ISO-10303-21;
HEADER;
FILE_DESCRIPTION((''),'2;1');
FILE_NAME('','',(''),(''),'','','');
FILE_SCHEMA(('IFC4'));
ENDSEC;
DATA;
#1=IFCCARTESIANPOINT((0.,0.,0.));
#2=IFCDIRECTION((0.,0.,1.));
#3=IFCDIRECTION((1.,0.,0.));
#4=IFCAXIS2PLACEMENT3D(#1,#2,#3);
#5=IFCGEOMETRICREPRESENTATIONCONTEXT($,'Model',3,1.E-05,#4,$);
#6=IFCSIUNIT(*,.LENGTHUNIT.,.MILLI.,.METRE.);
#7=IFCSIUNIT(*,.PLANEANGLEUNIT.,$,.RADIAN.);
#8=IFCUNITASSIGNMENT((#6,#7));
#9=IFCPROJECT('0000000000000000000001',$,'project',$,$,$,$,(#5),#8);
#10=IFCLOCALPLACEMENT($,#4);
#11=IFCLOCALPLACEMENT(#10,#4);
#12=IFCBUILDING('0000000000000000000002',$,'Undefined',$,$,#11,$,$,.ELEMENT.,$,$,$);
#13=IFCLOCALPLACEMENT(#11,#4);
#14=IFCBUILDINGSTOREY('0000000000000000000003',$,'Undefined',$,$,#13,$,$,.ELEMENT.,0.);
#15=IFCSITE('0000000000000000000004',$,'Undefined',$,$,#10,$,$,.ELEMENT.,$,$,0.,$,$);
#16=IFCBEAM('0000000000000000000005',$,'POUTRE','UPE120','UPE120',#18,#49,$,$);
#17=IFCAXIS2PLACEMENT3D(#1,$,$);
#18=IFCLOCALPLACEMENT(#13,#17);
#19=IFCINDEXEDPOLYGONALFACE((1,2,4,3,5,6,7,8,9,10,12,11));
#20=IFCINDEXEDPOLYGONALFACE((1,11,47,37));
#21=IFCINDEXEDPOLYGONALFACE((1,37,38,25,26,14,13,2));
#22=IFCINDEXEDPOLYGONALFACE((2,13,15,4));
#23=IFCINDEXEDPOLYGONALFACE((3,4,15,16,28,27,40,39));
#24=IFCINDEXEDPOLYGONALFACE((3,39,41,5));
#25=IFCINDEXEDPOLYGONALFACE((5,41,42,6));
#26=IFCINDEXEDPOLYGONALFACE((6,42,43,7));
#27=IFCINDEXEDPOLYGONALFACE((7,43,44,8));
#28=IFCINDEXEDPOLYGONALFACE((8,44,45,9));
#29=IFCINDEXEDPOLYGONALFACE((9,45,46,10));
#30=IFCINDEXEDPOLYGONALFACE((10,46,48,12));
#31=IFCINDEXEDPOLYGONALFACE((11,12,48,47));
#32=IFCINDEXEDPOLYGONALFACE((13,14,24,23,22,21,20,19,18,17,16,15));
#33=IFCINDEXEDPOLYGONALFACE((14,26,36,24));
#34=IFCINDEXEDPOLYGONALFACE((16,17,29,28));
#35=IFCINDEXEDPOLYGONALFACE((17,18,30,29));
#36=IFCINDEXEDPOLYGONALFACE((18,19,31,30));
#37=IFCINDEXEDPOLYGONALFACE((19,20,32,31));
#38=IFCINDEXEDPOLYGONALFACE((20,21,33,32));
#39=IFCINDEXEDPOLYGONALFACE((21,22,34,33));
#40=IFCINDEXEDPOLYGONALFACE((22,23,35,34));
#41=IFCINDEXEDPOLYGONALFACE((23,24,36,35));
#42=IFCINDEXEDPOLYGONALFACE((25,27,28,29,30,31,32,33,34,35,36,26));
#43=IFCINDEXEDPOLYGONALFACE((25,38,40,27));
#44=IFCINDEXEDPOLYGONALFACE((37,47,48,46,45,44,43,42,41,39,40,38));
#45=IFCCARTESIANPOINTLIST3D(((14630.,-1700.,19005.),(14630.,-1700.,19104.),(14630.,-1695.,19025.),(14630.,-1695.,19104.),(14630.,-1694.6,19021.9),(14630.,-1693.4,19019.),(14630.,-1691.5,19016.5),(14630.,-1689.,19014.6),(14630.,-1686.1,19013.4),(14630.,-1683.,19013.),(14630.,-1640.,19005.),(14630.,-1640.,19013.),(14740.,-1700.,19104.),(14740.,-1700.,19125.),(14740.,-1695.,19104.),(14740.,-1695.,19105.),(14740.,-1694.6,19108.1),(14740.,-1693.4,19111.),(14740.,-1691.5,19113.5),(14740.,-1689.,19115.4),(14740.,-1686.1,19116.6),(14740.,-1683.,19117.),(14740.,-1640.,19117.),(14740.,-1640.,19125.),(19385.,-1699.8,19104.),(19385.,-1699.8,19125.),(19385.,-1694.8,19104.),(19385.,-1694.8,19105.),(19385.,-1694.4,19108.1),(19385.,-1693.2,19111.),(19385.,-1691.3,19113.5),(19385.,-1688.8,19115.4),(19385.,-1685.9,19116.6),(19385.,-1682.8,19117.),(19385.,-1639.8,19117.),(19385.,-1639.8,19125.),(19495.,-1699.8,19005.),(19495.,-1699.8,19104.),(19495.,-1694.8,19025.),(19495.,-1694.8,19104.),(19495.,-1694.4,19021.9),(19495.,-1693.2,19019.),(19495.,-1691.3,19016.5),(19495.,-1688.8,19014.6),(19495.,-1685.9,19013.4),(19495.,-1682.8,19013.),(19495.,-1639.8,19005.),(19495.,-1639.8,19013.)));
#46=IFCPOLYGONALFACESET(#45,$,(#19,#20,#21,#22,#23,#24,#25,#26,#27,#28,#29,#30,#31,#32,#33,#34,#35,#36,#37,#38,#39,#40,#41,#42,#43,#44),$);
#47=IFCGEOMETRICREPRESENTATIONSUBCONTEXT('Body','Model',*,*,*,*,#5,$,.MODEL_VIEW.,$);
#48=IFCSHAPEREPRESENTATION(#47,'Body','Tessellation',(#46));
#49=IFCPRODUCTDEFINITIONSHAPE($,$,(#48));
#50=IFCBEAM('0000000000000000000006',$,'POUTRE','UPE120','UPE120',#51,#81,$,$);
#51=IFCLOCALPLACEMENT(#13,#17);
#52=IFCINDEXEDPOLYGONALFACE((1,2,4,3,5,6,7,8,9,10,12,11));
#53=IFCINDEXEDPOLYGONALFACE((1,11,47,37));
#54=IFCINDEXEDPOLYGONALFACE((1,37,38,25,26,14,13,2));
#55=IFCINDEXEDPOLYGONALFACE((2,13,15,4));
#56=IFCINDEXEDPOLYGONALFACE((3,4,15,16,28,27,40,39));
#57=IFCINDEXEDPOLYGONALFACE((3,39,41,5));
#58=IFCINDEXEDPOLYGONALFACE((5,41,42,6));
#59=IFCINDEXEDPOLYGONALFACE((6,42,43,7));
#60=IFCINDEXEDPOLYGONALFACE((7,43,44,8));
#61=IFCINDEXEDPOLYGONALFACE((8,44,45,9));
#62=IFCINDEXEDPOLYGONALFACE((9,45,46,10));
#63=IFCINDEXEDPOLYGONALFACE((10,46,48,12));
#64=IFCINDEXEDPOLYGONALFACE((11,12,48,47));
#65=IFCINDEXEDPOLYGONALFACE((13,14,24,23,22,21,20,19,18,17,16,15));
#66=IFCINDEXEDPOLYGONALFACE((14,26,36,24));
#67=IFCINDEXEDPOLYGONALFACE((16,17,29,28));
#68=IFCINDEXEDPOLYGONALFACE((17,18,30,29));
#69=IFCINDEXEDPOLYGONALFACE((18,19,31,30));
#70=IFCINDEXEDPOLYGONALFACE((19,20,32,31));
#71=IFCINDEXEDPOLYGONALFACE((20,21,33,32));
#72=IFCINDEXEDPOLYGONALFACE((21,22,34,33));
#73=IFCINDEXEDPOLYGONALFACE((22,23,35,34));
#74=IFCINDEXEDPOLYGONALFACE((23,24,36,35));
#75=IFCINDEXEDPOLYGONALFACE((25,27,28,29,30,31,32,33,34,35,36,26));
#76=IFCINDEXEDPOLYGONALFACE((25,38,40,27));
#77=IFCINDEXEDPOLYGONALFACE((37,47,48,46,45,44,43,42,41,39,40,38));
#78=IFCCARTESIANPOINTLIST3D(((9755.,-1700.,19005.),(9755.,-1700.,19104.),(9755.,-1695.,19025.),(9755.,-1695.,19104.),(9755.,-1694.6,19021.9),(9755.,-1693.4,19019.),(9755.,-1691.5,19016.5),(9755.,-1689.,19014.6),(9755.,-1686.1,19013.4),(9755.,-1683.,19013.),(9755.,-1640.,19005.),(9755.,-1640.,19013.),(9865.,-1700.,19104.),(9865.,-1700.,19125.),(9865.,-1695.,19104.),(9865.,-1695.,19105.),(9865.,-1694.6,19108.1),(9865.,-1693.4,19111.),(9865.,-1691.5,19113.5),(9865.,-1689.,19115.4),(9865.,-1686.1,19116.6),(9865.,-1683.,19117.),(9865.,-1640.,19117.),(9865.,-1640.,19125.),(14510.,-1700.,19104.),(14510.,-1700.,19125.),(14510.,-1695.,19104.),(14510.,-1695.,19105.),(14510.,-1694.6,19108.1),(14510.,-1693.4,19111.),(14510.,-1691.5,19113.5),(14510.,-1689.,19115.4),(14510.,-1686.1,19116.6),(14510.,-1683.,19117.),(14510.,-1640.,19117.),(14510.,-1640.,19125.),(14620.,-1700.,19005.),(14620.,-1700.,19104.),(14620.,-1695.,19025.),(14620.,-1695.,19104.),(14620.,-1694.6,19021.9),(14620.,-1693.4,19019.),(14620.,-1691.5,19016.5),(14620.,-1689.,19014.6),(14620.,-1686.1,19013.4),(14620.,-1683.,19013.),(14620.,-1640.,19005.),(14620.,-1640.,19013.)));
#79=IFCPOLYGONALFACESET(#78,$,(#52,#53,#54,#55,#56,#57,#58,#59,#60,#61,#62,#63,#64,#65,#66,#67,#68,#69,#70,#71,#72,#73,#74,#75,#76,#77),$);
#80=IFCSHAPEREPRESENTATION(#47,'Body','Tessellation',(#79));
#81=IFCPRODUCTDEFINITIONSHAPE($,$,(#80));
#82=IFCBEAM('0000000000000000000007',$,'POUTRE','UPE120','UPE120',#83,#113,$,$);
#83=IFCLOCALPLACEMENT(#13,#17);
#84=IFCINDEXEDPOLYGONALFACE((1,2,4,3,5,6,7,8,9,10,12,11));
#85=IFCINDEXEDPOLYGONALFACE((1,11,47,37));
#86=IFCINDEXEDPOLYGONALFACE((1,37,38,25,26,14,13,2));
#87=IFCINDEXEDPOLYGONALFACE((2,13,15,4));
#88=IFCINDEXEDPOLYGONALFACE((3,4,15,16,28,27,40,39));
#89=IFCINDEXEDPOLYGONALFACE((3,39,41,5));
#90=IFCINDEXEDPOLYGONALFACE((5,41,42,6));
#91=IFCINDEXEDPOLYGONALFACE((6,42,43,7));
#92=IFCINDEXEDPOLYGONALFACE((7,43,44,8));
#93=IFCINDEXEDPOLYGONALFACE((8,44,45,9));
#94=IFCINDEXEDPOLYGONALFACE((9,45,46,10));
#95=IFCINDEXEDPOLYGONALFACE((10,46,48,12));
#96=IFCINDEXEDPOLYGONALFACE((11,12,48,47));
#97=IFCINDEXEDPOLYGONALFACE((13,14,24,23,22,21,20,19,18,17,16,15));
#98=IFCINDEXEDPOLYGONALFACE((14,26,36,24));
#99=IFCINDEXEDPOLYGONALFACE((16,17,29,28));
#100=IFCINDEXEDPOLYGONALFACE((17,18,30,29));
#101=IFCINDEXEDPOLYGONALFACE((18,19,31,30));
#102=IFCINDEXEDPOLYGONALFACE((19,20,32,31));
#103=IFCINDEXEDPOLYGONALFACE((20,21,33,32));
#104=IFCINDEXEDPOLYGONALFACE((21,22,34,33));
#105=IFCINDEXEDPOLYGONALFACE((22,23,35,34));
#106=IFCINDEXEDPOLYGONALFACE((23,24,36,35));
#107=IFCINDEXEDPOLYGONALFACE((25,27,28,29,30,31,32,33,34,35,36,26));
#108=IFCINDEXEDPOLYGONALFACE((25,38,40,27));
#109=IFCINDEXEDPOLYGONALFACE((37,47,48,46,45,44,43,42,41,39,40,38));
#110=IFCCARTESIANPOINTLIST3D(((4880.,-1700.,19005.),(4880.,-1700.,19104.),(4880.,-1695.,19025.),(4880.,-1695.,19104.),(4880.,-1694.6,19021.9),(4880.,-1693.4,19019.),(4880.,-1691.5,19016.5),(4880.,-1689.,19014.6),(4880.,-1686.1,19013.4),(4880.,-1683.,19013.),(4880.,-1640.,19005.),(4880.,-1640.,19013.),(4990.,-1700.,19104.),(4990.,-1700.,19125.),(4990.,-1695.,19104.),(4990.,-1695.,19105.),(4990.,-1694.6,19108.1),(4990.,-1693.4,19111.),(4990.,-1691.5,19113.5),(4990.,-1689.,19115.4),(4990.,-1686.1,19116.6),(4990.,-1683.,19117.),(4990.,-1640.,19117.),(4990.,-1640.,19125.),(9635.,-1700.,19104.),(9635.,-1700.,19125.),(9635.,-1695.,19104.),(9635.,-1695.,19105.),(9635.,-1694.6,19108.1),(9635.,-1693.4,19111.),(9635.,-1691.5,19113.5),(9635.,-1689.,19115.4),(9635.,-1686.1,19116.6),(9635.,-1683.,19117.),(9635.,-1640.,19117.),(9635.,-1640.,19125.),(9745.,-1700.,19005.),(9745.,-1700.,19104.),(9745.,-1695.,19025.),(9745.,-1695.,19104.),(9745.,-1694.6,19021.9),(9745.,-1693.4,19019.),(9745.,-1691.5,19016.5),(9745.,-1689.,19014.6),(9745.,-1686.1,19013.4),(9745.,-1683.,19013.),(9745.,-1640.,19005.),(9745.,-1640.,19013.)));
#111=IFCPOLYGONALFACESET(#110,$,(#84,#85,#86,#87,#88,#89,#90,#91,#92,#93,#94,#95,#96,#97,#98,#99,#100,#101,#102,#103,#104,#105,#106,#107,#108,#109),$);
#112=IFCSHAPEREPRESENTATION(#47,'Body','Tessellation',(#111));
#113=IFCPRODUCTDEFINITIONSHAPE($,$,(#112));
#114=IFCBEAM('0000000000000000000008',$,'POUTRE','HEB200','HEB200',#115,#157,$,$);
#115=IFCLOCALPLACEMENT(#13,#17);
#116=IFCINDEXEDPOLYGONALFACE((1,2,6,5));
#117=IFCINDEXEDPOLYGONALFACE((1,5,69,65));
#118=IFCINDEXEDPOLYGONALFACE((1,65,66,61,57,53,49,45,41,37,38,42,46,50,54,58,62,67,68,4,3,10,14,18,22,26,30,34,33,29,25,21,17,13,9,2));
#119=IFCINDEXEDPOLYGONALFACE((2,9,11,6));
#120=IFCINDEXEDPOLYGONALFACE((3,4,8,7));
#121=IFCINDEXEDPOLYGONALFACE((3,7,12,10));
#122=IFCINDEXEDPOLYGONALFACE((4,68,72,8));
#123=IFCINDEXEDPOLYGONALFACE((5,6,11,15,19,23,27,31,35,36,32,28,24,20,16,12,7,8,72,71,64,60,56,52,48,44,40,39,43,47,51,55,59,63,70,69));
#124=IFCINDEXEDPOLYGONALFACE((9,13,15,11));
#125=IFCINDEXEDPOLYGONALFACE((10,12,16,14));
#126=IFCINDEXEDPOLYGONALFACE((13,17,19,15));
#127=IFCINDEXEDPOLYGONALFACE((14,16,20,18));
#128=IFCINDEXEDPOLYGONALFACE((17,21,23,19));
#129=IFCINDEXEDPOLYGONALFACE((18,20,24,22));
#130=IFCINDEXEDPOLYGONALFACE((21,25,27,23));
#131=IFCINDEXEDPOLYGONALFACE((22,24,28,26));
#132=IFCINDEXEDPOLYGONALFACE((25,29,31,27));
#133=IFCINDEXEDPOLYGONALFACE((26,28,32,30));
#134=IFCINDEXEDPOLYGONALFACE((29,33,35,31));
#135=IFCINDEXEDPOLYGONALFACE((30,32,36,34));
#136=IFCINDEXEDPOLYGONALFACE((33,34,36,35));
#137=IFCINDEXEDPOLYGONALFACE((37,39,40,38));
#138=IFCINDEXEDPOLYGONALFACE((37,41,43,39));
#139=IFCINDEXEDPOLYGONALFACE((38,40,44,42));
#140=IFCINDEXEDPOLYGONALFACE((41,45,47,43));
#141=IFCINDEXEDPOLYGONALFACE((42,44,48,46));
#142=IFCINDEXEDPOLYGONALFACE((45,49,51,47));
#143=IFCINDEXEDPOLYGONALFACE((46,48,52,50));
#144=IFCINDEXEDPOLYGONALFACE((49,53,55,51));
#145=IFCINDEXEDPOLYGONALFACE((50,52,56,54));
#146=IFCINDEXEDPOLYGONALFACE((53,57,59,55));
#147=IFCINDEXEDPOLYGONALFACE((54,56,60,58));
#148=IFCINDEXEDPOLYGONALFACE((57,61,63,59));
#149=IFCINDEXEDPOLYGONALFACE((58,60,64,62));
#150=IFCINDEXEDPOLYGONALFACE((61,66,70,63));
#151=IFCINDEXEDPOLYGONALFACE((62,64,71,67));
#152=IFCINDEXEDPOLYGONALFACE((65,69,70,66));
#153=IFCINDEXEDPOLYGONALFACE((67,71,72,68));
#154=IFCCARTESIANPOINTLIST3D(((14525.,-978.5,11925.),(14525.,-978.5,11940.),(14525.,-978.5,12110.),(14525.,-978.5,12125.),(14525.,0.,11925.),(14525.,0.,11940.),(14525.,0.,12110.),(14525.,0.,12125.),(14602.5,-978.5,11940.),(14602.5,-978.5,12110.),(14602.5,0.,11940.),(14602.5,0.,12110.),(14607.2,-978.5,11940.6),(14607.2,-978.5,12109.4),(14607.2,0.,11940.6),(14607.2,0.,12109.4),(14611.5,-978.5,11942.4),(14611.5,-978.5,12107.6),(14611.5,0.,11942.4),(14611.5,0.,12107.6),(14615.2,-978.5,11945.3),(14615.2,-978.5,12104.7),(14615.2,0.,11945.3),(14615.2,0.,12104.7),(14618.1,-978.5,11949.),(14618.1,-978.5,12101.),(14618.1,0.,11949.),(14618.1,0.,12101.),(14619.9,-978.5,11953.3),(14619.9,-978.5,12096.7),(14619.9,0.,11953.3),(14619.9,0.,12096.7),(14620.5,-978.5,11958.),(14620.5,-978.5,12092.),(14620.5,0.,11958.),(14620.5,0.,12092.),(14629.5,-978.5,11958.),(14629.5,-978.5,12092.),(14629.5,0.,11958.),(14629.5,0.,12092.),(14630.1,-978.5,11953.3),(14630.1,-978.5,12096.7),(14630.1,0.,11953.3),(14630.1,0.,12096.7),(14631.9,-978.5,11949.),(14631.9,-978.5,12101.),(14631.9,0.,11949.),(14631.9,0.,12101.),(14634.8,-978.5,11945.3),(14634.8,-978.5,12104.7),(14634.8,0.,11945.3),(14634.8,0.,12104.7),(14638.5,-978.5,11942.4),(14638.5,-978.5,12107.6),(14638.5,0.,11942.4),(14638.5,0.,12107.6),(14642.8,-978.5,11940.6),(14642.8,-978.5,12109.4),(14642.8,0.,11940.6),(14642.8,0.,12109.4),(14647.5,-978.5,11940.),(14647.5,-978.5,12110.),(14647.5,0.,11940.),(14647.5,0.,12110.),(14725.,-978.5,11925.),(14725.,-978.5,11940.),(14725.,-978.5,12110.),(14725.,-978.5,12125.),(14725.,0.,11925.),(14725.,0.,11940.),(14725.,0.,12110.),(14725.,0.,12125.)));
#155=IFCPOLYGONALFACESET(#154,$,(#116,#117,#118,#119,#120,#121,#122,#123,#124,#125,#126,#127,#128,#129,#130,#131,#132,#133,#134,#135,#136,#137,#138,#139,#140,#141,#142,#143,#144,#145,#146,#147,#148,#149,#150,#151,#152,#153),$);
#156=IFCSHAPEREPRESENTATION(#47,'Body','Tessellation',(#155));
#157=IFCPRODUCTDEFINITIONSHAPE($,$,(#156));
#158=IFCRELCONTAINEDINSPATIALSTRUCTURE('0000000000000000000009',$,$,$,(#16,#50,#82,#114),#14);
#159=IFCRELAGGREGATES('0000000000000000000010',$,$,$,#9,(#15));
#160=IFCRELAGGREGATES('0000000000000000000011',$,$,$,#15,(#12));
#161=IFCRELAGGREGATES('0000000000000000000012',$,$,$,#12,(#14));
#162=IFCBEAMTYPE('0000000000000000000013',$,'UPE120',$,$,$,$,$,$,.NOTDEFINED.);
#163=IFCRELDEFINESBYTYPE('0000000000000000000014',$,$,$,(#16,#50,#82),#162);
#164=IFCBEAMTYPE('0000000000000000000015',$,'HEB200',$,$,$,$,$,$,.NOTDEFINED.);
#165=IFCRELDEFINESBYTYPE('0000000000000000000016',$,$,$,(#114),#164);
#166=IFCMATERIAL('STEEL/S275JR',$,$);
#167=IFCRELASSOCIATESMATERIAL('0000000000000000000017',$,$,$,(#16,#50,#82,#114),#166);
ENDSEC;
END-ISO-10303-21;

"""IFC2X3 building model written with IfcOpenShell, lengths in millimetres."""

from ifc_helpers import new_model, si_unit, frame, origin_with_axes, origin_2d_with_axis, place, context, subcontext, project, spatial, rectangle, i_section, u_section, extrude, boolean, material, type_object, element, save


model = new_model("IFC2X3")

# Units and contexts
model_context = context("Model", 3, precision=1e-05, world=origin_with_axes())
body_context = subcontext(model_context, "Body", "Model", "MODEL_VIEW")
ifc_project = project(units=[si_unit("LENGTHUNIT", "METRE", prefix="MILLI"), si_unit("PLANEANGLEUNIT", "RADIAN")], contexts=[model_context])

# Site, building, storey
site_placement = place(None, origin_with_axes())
site = spatial("IfcSite", under=ifc_project, at=site_placement, Name="Undefined", CompositionType="ELEMENT", RefElevation=0.0)
building_placement = place(site_placement, origin_with_axes())
building = spatial("IfcBuilding", under=site, at=building_placement, Name="Undefined", CompositionType="ELEMENT")
storey_placement = place(building_placement, origin_with_axes())
storey = spatial("IfcBuildingStorey", under=building, at=storey_placement, Name="Undefined", CompositionType="ELEMENT", Elevation=0.0)

# Shared definitions
ifc_material_1 = material(Name="STEEL/S275JR")

# Beams
beam_type_1 = type_object("IfcBeamType", Name="UPE120", PredefinedType="NOTDEFINED")
beam_1_placement = place(storey_placement, frame((14625.0, -1670.0, 19065.0), z_axis=(0.0, 0.0, -1.0), x_axis=(1.0, 0.000043, 0.0)))
element("IfcBeam", 1, at=beam_1_placement, inside=storey, type_object=beam_type_1, material=ifc_material_1, Name="POUTRE", Description="UPE120", ObjectType="UPE120", context=body_context, shape_type="CSG", body=[
    boolean("DIFFERENCE", boolean("DIFFERENCE", extrude(u_section(Depth=120.0, FlangeWidth=60.0, WebThickness=5.0, FlangeThickness=8.0, FilletRadius=12.0, at=origin_2d_with_axis()), frame((4870.0, 0.0, 0.0), z_axis=(-1.0, 0.0, 0.0), x_axis=(0.0, -1.0, 0.0)), (0.0, 0.0, 1.0), 4865.0), extrude(rectangle(XDim=22.0, YDim=112.0, at=origin_2d_with_axis()), frame((4816.0, -31.0, -50.0), z_axis=(-0.000043, 1.0, 0.0), x_axis=(0.0, 0.0, 1.0)), (0.0, 0.0, 1.0), 62.2)), extrude(rectangle(XDim=22.0, YDim=112.0, at=origin_2d_with_axis()), frame((59.0, 31.0, -50.0), z_axis=(0.000043, -1.0, 0.0), x_axis=(0.0, 0.0, 1.0)), (0.0, 0.0, 1.0), 62.2)),
])
beam_2_placement = place(storey_placement, frame((9750.0, -1670.0, 19065.0), z_axis=(0.0, 0.0, -1.0), x_axis=(1.0, 0.0, 0.0)))
element("IfcBeam", 2, at=beam_2_placement, inside=storey, type_object=beam_type_1, material=ifc_material_1, Name="POUTRE", Description="UPE120", ObjectType="UPE120", context=body_context, shape_type="CSG", body=[
    boolean("DIFFERENCE", boolean("DIFFERENCE", extrude(u_section(Depth=120.0, FlangeWidth=60.0, WebThickness=5.0, FlangeThickness=8.0, FilletRadius=12.0, at=origin_2d_with_axis()), frame((4870.0, 0.0, 0.0), z_axis=(-1.0, 0.0, 0.0), x_axis=(0.0, -1.0, 0.0)), (0.0, 0.0, 1.0), 4865.0), extrude(rectangle(XDim=22.0, YDim=112.0, at=origin_2d_with_axis()), frame((4816.0, -31.0, -50.0), z_axis=(0.0, 1.0, 0.0), x_axis=(0.0, 0.0, 1.0)), (0.0, 0.0, 1.0), 62.0)), extrude(rectangle(XDim=22.0, YDim=112.0, at=origin_2d_with_axis()), frame((59.0, 31.0, -50.0), z_axis=(0.0, -1.0, 0.0), x_axis=(0.0, 0.0, 1.0)), (0.0, 0.0, 1.0), 62.0)),
])
beam_3_placement = place(storey_placement, frame((4875.0, -1670.0, 19065.0), z_axis=(0.0, 0.0, -1.0), x_axis=(1.0, 0.0, 0.0)))
element("IfcBeam", 3, at=beam_3_placement, inside=storey, type_object=beam_type_1, material=ifc_material_1, Name="POUTRE", Description="UPE120", ObjectType="UPE120", context=body_context, shape_type="CSG", body=[
    boolean("DIFFERENCE", boolean("DIFFERENCE", extrude(u_section(Depth=120.0, FlangeWidth=60.0, WebThickness=5.0, FlangeThickness=8.0, FilletRadius=12.0, at=origin_2d_with_axis()), frame((4870.0, 0.0, 0.0), z_axis=(-1.0, 0.0, 0.0), x_axis=(0.0, -1.0, 0.0)), (0.0, 0.0, 1.0), 4865.0), extrude(rectangle(XDim=22.0, YDim=112.0, at=origin_2d_with_axis()), frame((4816.0, -31.0, -50.0), z_axis=(0.0, 1.0, 0.0), x_axis=(0.0, 0.0, 1.0)), (0.0, 0.0, 1.0), 62.0)), extrude(rectangle(XDim=22.0, YDim=112.0, at=origin_2d_with_axis()), frame((59.0, 31.0, -50.0), z_axis=(0.0, -1.0, 0.0), x_axis=(0.0, 0.0, 1.0)), (0.0, 0.0, 1.0), 62.0)),
])
beam_type_2 = type_object("IfcBeamType", Name="HEB200", PredefinedType="NOTDEFINED")
beam_4_placement = place(storey_placement, frame((14625.0, 0.0, 12025.0), z_axis=(0.0, 0.0, 1.0), x_axis=(0.0, -1.0, 0.0)))
element("IfcBeam", 4, at=beam_4_placement, inside=storey, type_object=beam_type_2, material=ifc_material_1, Name="POUTRE", Description="HEB200", ObjectType="HEB200", context=body_context, shape_type="SweptSolid", body=[
    extrude(i_section(OverallWidth=200.0, OverallDepth=200.0, WebThickness=9.0, FlangeThickness=15.0, FilletRadius=18.0, at=origin_2d_with_axis()), frame((978.5, 0.0, 0.0), z_axis=(-1.0, 0.0, 0.0), x_axis=(0.0, -1.0, 0.0)), (0.0, 0.0, 1.0), 978.5),
])

save(model, "model.ifc")
